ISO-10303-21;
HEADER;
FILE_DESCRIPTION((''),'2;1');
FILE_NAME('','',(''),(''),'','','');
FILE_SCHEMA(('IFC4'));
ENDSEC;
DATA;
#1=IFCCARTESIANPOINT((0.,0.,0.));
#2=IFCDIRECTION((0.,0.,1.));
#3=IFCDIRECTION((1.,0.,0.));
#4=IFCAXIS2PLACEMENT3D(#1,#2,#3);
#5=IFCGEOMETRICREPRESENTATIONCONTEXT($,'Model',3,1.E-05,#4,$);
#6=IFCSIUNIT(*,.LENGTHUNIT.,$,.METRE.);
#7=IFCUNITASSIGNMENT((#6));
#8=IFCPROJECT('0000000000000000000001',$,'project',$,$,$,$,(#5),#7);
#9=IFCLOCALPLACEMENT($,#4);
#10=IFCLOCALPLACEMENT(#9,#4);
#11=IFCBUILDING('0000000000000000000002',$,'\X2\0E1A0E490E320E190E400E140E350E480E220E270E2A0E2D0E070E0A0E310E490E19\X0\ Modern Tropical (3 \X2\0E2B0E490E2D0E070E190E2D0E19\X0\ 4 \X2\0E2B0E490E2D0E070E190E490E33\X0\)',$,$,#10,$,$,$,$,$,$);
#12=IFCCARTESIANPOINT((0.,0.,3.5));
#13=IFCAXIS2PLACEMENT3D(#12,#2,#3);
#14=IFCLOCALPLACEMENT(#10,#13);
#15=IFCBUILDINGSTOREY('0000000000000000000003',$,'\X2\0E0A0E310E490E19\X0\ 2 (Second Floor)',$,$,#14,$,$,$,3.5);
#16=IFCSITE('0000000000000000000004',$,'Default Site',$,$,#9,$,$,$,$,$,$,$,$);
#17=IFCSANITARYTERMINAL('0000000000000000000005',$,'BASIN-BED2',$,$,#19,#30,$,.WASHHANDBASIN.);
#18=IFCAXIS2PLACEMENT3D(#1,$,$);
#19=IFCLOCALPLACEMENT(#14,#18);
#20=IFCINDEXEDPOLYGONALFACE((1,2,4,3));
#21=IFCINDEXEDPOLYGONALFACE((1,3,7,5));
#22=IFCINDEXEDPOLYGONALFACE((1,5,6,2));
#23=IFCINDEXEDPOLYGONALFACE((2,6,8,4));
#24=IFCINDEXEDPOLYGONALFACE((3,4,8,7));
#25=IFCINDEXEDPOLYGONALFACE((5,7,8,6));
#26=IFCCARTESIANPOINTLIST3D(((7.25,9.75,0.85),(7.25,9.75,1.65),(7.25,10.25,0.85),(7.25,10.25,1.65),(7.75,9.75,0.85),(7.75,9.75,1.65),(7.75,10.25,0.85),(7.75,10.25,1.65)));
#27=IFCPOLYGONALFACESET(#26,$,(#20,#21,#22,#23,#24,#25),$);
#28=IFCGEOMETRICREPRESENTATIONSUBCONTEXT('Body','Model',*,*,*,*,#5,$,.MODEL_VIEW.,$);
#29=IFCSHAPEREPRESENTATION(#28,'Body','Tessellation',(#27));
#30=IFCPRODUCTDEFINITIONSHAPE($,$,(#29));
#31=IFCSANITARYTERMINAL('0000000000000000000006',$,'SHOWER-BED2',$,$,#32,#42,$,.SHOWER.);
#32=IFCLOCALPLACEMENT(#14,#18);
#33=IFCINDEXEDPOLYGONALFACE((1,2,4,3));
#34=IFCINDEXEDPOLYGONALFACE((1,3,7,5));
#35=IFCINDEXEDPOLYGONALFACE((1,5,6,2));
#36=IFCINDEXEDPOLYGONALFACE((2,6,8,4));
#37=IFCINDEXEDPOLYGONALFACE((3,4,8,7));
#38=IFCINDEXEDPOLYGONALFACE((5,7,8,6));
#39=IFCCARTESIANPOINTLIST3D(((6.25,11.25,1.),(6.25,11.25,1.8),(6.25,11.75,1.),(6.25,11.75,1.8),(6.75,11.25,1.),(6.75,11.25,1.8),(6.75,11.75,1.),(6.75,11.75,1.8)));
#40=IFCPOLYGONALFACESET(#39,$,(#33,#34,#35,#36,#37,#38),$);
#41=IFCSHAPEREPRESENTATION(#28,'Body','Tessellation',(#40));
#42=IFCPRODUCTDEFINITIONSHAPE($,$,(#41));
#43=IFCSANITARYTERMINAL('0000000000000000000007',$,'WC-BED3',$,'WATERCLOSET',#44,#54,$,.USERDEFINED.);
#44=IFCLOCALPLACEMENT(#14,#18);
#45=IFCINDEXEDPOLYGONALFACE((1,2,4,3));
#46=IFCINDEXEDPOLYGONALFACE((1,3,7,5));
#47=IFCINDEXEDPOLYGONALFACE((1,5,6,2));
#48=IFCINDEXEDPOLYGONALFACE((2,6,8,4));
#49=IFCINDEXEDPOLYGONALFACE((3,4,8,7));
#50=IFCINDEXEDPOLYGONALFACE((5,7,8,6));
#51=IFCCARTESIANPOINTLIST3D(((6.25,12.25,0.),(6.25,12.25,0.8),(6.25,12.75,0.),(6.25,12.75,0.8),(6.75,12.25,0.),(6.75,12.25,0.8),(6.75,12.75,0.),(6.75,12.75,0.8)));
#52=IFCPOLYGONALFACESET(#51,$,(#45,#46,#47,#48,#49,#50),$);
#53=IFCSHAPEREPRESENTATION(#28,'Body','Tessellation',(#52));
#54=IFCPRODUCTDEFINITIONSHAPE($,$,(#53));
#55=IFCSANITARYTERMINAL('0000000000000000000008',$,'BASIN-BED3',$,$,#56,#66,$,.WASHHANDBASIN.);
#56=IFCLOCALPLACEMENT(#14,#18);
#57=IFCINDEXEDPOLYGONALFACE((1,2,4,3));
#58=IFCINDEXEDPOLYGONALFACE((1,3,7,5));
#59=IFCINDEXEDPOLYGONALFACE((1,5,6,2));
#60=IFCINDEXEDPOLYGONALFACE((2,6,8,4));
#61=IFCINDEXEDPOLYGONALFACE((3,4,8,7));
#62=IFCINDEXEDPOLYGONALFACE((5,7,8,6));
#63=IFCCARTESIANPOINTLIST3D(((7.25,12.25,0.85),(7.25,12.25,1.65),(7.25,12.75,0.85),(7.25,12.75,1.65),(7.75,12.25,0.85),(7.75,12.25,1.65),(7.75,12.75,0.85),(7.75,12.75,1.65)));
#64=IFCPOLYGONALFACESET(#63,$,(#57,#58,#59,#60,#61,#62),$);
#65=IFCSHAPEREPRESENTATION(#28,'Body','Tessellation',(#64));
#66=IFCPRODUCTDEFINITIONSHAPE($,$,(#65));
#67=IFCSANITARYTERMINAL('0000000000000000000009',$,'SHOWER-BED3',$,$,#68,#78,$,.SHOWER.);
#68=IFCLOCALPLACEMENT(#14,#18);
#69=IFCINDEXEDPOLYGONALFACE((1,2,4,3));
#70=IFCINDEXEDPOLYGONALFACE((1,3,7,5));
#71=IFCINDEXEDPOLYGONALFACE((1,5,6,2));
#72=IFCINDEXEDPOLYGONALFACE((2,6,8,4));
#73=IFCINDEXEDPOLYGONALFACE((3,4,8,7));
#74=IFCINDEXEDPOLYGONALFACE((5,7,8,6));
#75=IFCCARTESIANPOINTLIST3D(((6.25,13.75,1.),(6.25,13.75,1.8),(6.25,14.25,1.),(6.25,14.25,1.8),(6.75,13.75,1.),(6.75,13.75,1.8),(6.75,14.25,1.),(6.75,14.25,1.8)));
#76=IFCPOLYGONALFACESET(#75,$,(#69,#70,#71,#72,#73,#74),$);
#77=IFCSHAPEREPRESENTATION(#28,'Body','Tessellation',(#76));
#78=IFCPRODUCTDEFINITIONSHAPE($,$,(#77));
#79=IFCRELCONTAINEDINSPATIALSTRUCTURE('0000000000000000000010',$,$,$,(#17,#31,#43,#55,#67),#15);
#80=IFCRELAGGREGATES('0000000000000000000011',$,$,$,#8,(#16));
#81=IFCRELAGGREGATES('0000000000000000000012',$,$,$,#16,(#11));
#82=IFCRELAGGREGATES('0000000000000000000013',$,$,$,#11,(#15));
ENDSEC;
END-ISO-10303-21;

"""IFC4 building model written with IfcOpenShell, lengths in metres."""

from ifc_helpers import new_model, si_unit, frame, origin_with_axes, origin_2d, place, context, subcontext, project, spatial, rectangle, extrude, element, save


model = new_model("IFC4")

# Units and contexts
model_context = context("Model", 3, precision=1e-05, world=origin_with_axes())
body_context = subcontext(model_context, "Body", "Model", "MODEL_VIEW")
ifc_project = project(units=[si_unit("LENGTHUNIT", "METRE")], contexts=[model_context])

# Site, building, storey
site_placement = place(None, origin_with_axes())
site = spatial("IfcSite", under=ifc_project, at=site_placement, Name="Default Site")
building_placement = place(site_placement, origin_with_axes())
building = spatial("IfcBuilding", under=site, at=building_placement, Name="บ้านเดี่ยวสองชั้น Modern Tropical (3 ห้องนอน 4 ห้องน้ำ)")
storey_placement = place(building_placement, frame((0.0, 0.0, 3.5), z_axis=(0.0, 0.0, 1.0), x_axis=(1.0, 0.0, 0.0)))
storey = spatial("IfcBuildingStorey", under=building, at=storey_placement, Name="ชั้น 2 (Second Floor)", Elevation=3.5)

# Sanitary terminals
sanitary_terminal_1_placement = place(storey_placement, frame((7.5, 10.0, 0.85), z_axis=(0.0, 0.0, 1.0), x_axis=(1.0, 0.0, 0.0)))
element("IfcSanitaryTerminal", 1, at=sanitary_terminal_1_placement, inside=storey, Name="BASIN-BED2", PredefinedType="WASHHANDBASIN", context=body_context, shape_type="SweptSolid", body=[
    extrude(rectangle(XDim=0.5, YDim=0.5, at=origin_2d()), origin_with_axes(), (0.0, 0.0, 1.0), 0.8),
])
sanitary_terminal_2_placement = place(storey_placement, frame((6.5, 11.5, 1.0), z_axis=(0.0, 0.0, 1.0), x_axis=(1.0, 0.0, 0.0)))
element("IfcSanitaryTerminal", 2, at=sanitary_terminal_2_placement, inside=storey, Name="SHOWER-BED2", PredefinedType="SHOWER", context=body_context, shape_type="SweptSolid", body=[
    extrude(rectangle(XDim=0.5, YDim=0.5, at=origin_2d()), origin_with_axes(), (0.0, 0.0, 1.0), 0.8),
])
sanitary_terminal_3_placement = place(storey_placement, frame((6.5, 12.5, 0.0), z_axis=(0.0, 0.0, 1.0), x_axis=(1.0, 0.0, 0.0)))
element("IfcSanitaryTerminal", 3, at=sanitary_terminal_3_placement, inside=storey, Name="WC-BED3", ObjectType="WATERCLOSET", PredefinedType="USERDEFINED", context=body_context, shape_type="SweptSolid", body=[
    extrude(rectangle(XDim=0.5, YDim=0.5, at=origin_2d()), origin_with_axes(), (0.0, 0.0, 1.0), 0.8),
])
sanitary_terminal_4_placement = place(storey_placement, frame((7.5, 12.5, 0.85), z_axis=(0.0, 0.0, 1.0), x_axis=(1.0, 0.0, 0.0)))
element("IfcSanitaryTerminal", 4, at=sanitary_terminal_4_placement, inside=storey, Name="BASIN-BED3", PredefinedType="WASHHANDBASIN", context=body_context, shape_type="SweptSolid", body=[
    extrude(rectangle(XDim=0.5, YDim=0.5, at=origin_2d()), origin_with_axes(), (0.0, 0.0, 1.0), 0.8),
])
sanitary_terminal_5_placement = place(storey_placement, frame((6.5, 14.0, 1.0), z_axis=(0.0, 0.0, 1.0), x_axis=(1.0, 0.0, 0.0)))
element("IfcSanitaryTerminal", 5, at=sanitary_terminal_5_placement, inside=storey, Name="SHOWER-BED3", PredefinedType="SHOWER", context=body_context, shape_type="SweptSolid", body=[
    extrude(rectangle(XDim=0.5, YDim=0.5, at=origin_2d()), origin_with_axes(), (0.0, 0.0, 1.0), 0.8),
])

save(model, "model.ifc")
